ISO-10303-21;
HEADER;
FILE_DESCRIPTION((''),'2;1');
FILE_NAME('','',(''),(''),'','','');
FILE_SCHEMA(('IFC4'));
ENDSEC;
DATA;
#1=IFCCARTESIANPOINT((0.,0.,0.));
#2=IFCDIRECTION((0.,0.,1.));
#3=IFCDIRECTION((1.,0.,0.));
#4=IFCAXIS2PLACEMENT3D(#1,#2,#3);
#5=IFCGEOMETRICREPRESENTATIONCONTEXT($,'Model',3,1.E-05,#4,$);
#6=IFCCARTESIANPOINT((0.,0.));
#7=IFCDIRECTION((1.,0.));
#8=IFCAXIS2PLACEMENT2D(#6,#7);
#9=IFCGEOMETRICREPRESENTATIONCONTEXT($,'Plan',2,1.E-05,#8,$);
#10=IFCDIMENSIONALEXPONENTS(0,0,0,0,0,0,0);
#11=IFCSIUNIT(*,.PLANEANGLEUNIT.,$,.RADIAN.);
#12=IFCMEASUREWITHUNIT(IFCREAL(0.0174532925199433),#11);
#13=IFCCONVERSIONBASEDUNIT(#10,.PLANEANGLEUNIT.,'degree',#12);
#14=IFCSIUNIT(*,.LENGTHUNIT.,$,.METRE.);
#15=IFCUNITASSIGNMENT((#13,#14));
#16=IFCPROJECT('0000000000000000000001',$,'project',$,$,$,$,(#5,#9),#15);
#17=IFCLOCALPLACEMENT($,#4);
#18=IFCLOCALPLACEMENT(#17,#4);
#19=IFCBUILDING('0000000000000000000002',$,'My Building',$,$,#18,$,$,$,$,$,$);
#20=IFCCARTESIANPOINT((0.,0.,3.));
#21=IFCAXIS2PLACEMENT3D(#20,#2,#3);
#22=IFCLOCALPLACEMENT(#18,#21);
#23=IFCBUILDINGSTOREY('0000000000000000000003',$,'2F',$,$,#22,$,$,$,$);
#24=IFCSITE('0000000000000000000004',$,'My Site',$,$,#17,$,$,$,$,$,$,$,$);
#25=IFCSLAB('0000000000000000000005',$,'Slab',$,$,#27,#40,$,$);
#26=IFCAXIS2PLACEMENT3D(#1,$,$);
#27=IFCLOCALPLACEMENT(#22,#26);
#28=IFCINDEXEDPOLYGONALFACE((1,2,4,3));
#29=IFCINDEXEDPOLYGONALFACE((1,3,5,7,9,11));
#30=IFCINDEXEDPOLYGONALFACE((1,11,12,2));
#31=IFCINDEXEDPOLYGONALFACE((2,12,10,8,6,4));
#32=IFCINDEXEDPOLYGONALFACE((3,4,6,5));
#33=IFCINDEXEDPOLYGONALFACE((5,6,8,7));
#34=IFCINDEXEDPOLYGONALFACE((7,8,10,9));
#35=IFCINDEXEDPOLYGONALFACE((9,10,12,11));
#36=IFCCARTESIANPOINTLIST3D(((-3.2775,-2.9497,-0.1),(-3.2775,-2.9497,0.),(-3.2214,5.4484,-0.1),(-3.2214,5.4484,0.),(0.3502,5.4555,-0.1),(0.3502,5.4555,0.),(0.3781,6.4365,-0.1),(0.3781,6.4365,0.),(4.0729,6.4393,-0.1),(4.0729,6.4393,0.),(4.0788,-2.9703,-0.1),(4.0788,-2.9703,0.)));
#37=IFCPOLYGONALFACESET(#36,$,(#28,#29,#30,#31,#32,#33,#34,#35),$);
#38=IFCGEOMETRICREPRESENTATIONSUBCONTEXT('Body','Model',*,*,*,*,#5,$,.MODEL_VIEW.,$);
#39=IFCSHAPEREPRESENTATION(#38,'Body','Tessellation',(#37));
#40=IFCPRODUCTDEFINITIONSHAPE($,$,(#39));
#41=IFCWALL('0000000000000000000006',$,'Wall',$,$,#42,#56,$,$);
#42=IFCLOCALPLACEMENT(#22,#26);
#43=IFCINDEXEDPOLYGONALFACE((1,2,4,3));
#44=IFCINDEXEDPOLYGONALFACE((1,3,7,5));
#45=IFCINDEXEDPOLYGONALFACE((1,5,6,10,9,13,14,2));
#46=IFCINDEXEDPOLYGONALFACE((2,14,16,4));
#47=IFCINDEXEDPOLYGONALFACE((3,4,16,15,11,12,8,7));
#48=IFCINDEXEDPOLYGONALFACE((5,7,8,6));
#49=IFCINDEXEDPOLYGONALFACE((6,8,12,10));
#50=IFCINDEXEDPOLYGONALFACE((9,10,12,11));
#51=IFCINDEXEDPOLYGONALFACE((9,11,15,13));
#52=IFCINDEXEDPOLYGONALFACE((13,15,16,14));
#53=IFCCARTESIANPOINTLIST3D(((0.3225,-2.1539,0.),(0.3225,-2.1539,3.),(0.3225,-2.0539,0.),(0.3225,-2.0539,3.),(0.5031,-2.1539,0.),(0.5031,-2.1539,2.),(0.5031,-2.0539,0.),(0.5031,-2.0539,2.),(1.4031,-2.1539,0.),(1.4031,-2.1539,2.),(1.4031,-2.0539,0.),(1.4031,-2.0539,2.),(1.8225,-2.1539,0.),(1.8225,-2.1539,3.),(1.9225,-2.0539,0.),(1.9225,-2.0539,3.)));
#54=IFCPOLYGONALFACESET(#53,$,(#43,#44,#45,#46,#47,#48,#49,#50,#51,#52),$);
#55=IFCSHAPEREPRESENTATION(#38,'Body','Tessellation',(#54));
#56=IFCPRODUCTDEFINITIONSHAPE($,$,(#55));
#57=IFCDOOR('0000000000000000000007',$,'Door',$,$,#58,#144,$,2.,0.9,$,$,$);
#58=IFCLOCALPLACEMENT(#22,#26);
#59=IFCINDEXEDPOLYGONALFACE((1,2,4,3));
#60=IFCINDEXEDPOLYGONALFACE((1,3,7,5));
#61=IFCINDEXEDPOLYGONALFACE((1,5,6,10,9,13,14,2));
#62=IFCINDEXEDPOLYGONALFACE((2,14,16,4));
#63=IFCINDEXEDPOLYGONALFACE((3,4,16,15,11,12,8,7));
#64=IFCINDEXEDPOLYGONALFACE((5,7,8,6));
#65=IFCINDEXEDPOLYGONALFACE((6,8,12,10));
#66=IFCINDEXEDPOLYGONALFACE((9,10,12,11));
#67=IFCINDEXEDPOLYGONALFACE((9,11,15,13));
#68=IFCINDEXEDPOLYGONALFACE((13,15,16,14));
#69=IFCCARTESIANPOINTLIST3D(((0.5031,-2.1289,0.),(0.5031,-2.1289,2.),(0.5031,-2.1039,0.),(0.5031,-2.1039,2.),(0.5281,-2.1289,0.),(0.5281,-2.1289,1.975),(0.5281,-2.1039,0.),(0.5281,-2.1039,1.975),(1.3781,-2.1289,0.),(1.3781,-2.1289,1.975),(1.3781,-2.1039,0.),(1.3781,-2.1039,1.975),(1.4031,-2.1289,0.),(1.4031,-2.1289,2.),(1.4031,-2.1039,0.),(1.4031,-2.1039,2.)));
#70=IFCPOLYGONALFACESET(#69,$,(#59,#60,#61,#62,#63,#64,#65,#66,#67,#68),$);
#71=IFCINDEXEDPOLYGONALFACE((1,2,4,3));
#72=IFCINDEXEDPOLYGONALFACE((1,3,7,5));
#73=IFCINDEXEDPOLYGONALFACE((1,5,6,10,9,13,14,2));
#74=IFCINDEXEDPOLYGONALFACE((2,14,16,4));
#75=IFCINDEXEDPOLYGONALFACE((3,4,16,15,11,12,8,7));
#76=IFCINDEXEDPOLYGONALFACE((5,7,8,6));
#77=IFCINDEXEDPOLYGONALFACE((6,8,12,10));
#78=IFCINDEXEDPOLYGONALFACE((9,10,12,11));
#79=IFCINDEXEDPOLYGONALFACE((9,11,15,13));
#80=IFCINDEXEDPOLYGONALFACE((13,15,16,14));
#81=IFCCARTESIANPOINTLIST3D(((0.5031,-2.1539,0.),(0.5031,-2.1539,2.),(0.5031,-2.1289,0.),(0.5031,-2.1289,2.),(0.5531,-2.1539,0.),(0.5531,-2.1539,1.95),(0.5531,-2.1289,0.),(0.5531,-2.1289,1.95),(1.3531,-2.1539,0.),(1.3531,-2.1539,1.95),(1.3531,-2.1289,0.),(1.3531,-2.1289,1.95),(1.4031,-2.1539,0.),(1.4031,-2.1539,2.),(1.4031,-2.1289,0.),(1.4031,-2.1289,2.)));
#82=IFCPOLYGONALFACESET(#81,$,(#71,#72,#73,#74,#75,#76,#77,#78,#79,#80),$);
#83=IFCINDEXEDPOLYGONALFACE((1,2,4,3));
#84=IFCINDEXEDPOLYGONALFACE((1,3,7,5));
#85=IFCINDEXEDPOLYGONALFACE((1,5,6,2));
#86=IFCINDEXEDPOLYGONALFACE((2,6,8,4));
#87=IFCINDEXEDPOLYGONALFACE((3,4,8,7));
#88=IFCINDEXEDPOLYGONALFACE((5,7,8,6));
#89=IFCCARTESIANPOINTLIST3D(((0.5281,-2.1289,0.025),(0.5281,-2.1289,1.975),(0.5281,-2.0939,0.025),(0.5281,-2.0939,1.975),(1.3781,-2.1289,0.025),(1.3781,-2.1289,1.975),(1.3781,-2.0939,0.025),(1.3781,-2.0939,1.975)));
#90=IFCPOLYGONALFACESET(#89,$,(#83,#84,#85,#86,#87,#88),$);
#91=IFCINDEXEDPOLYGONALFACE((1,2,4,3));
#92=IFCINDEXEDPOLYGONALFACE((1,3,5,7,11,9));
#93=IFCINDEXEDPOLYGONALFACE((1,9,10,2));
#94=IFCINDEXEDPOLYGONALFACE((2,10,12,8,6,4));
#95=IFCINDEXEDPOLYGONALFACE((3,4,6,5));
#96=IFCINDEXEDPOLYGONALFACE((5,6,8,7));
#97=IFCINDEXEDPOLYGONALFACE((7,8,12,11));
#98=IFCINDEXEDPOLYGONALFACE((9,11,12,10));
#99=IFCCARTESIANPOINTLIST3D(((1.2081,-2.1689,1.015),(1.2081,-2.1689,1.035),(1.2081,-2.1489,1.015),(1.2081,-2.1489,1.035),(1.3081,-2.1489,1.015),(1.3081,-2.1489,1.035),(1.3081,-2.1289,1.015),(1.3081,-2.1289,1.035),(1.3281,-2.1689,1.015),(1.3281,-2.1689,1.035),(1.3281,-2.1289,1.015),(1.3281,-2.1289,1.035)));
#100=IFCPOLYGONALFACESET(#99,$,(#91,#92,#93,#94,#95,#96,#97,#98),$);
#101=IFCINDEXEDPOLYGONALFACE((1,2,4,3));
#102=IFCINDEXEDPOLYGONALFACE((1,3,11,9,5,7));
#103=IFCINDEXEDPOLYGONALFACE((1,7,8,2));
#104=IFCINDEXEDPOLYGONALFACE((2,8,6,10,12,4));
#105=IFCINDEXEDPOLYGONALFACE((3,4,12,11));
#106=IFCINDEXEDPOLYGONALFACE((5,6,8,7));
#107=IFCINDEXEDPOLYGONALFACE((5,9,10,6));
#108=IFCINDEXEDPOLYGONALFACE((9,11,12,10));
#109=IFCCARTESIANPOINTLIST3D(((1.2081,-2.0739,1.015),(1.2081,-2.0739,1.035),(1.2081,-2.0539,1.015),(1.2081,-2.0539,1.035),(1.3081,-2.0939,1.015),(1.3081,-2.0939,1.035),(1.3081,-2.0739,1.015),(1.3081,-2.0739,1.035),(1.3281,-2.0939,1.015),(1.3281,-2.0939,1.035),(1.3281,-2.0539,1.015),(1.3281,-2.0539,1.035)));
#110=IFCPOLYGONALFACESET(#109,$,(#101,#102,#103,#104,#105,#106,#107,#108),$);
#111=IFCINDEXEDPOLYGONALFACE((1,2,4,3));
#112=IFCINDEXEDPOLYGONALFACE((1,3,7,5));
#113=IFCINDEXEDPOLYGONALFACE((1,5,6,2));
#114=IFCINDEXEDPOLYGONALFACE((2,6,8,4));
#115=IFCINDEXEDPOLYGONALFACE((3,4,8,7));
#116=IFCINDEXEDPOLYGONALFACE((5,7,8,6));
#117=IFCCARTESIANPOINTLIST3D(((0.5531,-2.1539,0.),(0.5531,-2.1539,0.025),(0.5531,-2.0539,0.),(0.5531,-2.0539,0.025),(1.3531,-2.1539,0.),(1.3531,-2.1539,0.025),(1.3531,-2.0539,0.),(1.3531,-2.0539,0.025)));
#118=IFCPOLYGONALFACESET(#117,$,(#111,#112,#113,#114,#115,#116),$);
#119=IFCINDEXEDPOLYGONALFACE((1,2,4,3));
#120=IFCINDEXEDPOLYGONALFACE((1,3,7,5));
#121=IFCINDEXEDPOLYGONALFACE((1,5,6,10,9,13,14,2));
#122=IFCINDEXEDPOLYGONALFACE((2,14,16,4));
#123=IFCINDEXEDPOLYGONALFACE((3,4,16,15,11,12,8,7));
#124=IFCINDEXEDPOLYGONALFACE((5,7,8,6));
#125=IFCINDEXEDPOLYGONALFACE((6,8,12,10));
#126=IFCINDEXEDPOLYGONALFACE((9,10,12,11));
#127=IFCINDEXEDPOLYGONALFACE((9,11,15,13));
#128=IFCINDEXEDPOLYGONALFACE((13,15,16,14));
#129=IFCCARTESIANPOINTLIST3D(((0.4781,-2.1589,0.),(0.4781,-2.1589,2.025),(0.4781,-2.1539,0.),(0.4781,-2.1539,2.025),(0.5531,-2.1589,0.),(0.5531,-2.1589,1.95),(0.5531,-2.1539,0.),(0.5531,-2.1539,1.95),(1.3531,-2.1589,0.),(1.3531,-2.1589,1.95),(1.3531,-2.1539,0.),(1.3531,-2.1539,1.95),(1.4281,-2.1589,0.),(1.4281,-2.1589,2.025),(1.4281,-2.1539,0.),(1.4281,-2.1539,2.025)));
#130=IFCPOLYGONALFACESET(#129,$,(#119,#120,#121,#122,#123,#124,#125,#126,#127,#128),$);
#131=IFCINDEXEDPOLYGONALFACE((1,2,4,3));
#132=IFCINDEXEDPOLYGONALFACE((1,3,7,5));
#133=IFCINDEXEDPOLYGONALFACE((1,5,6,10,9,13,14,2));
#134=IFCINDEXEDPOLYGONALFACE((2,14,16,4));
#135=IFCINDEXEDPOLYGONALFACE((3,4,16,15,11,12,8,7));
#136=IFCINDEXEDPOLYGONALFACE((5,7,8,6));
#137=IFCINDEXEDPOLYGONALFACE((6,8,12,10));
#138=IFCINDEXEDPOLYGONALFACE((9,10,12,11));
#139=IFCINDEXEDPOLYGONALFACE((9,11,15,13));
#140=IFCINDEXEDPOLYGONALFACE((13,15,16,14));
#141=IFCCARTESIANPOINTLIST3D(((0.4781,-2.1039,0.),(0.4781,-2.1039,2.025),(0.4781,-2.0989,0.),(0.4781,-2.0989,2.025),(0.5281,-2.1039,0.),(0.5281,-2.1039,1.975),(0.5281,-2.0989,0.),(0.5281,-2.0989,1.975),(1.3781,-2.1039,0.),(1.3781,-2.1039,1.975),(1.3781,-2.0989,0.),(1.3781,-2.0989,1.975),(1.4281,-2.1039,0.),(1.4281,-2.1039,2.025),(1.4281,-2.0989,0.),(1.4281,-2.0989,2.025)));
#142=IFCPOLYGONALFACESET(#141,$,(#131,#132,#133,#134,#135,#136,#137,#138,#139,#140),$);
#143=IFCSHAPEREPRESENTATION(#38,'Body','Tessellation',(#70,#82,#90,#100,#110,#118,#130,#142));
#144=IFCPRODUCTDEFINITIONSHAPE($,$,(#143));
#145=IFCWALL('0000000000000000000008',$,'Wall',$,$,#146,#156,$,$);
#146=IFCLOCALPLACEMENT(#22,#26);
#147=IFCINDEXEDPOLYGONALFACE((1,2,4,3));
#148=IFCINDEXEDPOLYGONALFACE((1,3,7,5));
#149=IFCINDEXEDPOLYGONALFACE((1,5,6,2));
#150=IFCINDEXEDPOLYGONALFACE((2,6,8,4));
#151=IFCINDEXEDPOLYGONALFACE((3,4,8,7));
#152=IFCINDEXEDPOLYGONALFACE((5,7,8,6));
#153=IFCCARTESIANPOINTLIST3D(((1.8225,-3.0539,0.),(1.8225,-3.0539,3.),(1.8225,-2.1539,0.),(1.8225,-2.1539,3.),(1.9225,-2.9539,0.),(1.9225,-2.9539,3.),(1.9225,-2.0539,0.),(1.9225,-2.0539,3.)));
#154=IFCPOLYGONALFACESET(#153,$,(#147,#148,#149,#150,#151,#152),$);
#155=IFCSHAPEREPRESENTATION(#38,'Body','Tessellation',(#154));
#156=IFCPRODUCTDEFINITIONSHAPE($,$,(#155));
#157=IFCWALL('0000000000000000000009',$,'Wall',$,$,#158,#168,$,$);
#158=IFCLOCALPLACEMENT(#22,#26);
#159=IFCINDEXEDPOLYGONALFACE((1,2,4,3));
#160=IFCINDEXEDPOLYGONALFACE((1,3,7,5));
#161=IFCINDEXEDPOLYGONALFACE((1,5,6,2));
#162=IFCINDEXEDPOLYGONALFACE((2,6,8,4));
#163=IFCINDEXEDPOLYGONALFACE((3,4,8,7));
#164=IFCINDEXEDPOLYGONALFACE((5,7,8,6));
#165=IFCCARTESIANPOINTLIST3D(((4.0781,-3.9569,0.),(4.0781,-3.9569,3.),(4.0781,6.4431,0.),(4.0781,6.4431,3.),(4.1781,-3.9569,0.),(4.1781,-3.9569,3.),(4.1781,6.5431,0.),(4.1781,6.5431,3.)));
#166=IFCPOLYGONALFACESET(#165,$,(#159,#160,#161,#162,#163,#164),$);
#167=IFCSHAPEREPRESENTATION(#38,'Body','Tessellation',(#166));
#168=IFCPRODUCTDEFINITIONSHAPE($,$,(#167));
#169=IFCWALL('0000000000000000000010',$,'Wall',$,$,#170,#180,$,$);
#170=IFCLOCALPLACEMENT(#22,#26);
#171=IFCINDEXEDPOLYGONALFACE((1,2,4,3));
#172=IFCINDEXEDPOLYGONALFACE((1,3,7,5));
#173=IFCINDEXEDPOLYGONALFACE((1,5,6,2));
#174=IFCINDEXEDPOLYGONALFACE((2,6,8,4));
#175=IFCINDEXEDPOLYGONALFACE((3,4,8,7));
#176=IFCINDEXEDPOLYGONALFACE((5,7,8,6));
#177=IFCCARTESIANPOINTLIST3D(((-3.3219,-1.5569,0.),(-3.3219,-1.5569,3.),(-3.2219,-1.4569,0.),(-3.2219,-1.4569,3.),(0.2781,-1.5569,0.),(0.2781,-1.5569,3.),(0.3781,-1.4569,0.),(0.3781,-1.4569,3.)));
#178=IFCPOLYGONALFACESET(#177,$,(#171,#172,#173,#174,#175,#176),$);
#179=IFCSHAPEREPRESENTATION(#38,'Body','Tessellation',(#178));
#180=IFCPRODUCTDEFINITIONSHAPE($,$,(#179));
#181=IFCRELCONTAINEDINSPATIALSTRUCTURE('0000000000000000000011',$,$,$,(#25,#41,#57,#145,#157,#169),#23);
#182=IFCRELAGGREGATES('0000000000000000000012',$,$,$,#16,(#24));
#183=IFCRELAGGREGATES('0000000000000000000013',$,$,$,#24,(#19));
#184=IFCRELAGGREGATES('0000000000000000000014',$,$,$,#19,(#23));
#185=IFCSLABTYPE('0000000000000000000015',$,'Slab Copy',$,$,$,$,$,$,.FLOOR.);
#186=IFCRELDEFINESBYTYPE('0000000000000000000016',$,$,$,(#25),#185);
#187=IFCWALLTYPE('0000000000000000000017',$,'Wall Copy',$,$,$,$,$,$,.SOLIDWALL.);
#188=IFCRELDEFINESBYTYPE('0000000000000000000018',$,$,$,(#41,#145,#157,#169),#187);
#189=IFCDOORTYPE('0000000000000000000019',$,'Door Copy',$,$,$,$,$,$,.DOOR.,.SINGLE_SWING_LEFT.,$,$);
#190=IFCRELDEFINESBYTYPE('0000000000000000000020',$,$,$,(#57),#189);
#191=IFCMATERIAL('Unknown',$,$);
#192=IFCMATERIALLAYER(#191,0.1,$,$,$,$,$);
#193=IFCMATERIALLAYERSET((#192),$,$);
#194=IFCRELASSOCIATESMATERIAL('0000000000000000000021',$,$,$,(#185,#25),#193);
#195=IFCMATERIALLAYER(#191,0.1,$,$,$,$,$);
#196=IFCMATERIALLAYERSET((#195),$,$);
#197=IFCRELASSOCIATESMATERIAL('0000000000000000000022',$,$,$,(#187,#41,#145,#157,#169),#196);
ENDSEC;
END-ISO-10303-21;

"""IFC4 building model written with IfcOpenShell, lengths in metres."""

from ifc_helpers import new_model, entity, si_unit, converted_unit, frame, origin_with_axes, origin_2d_with_axis, place, context, subcontext, project, spatial, line, indexed_curve, outline, extrude, shape, source, transform, mapped, material, layer, layer_set, layer_usage, type_object, type_shapes, element, fill, save


model = new_model("IFC4")

# Units and contexts
model_context = context("Model", 3, precision=1e-05, world=origin_with_axes())
plan_context = context("Plan", 2, precision=1e-05, world=origin_2d_with_axis())
body_context_1 = subcontext(model_context, "Body", "Model", "MODEL_VIEW")
body_context_2 = subcontext(plan_context, "Body", "Plan", "PLAN_VIEW")
ifc_project = project(units=[converted_unit("PLANEANGLEUNIT", "degree", entity("IfcReal", 0.0174532925199433), si_unit("PLANEANGLEUNIT", "RADIAN"), dimensions=[0, 0, 0, 0, 0, 0, 0]), si_unit("LENGTHUNIT", "METRE")], contexts=[model_context, plan_context])

# Site, building, storey
site_placement = place(None, origin_with_axes())
site = spatial("IfcSite", under=ifc_project, at=site_placement, Name="My Site")
building_placement = place(site_placement, origin_with_axes())
building = spatial("IfcBuilding", under=site, at=building_placement, Name="My Building")
storey_placement = place(building_placement, frame((0.0, 0.0, 3.0), z_axis=(0.0, 0.0, 1.0), x_axis=(1.0, 0.0, 0.0)))
storey = spatial("IfcBuildingStorey", under=building, at=storey_placement, Name="2F")

# Slab
ifc_material = material(Name="Unknown")
ifc_layer_1 = layer(ifc_material, 0.1)
ifc_layer_set_1 = layer_set([ifc_layer_1])
ifc_layer_usage_1 = layer_usage(ifc_layer_set_1, "AXIS3", "POSITIVE", -0.1)
slab_type = type_object("IfcSlabType", Name="Slab Copy", PredefinedType="FLOOR", material=ifc_layer_set_1)
slab_placement = place(storey_placement, frame((-3.2775, -2.9497, 0.0), z_axis=(0.0, 0.0, 1.0), x_axis=(1.0, 0.0, 0.0)))
element("IfcSlab", 1, at=slab_placement, inside=storey, type_object=slab_type, material=ifc_layer_usage_1, Name="Slab", context=body_context_1, shape_type="SweptSolid", body=[
    extrude(outline(indexed_curve([(0.0, 0.0), (7.3564, -0.0206), (7.3504, 9.389), (3.6556, 9.3862), (3.6278, 8.4052), (0.0561, 8.3981), (0.0, 0.0)])), frame((0.0, 0.0, -0.1), z_axis=(0.0, 0.0, 1.0), x_axis=(1.0, 0.0, 0.0)), (0.0, 0.0, 1.0), 0.1),
])

# Wall, opening, door
ifc_layer_2 = layer(ifc_material, 0.1)
ifc_layer_set_2 = layer_set([ifc_layer_2])
ifc_layer_usage_2 = layer_usage(ifc_layer_set_2, "AXIS2", "POSITIVE", 0.0)
wall_type = type_object("IfcWallType", Name="Wall Copy", PredefinedType="SOLIDWALL", material=ifc_layer_set_2)
wall_1_placement = place(storey_placement, frame((0.3225, -2.1539, 0.0), z_axis=(0.0, 0.0, 1.0), x_axis=(1.0, 0.0, 0.0)))
wall_1 = element("IfcWall", 2, at=wall_1_placement, inside=storey, type_object=wall_type, material=ifc_layer_usage_2, Name="Wall", context=body_context_1, shape_type="SweptSolid", body=[
    extrude(outline(indexed_curve([(0.0, 0.0), (0.0, 0.1), (1.6, 0.1), (1.5, 0.0)], segments=[line(1, 2, 3, 4, 1)])), origin_with_axes(), (0.0, 0.0, 1.0), 3.0),
])
shared_shape_1 = source(origin_with_axes(), body_context_1, "Body", "SweptSolid", [
    extrude(outline(indexed_curve([(0.0, 0.0), (0.9, 0.0), (0.9, 2.0), (0.0, 2.0)], segments=[line(1, 2, 3, 4, 1)])), frame((0.0, -0.6, 0.0), z_axis=(0.0, -1.0, 0.0), x_axis=(1.0, 0.0, 0.0)), (0.0, 0.0, -1.0), 1.2),
])
opening_placement = place(wall_1_placement, frame((0.1806, 0.0, 0.0), z_axis=(0.0, 0.0, 1.0), x_axis=(1.0, 0.0, 0.0)))
opening = element("IfcOpeningElement", 3, at=opening_placement, cuts=wall_1, PredefinedType="OPENING", context=body_context_1, shape_type="MappedRepresentation", body=[
    mapped(shared_shape_1, transform((0.0, 0.0, 0.0), x_axis=(1.0, 0.0, 0.0), y_axis=(0.0, 1.0, 0.0), z_axis=(0.0, 0.0, 1.0), scale=1.0)),
])
door_type = type_object("IfcDoorType", Name="Door Copy", OperationType="SINGLE_SWING_LEFT", PredefinedType="DOOR")
shared_shape_2 = source(origin_with_axes(), body_context_1, "Body", "SweptSolid", [
    extrude(outline(indexed_curve([(0.0, 0.0), (0.0, 2.0), (0.9, 2.0), (0.9, 0.0), (0.875, 0.0), (0.875, 1.975), (0.025, 1.975), (0.025, 0.0)], segments=[line(1, 2, 3, 4, 5, 6, 7, 8, 1)])), frame((0.0, 0.025, 0.0), z_axis=(0.0, -1.0, 0.0), x_axis=(1.0, 0.0, 0.0)), (0.0, 0.0, -1.0), 0.025),
    extrude(outline(indexed_curve([(0.0, 0.0), (0.0, 2.0), (0.9, 2.0), (0.9, 0.0), (0.85, 0.0), (0.85, 1.95), (0.05, 1.95), (0.05, 0.0)], segments=[line(1, 2, 3, 4, 5, 6, 7, 8, 1)])), frame((0.0, 0.0, 0.0), z_axis=(0.0, -1.0, 0.0), x_axis=(1.0, 0.0, 0.0)), (0.0, 0.0, -1.0), 0.025),
    extrude(outline(indexed_curve([(0.0, 0.0), (0.85, 0.0), (0.85, 0.035), (0.0, 0.035)], segments=[line(1, 2, 3, 4, 1)])), frame((0.025, 0.025, 0.025), z_axis=(0.0, 0.0, 1.0), x_axis=(1.0, 0.0, 0.0)), (0.0, 0.0, 1.0), 1.95),
    extrude(outline(indexed_curve([(0.0, 0.0), (0.0, -0.04), (-0.12, -0.04), (-0.12, -0.02), (-0.02, -0.02), (-0.02, 0.0)], segments=[line(1, 2, 3, 4, 5, 6, 1)])), frame((0.825, 0.025, 1.015), z_axis=(0.0, 0.0, 1.0), x_axis=(1.0, 0.0, 0.0)), (0.0, 0.0, 1.0), 0.02),
    extrude(outline(indexed_curve([(0.0, 0.0), (0.0, 0.04), (-0.12, 0.04), (-0.12, 0.02), (-0.02, 0.02), (-0.02, 0.0)], segments=[line(1, 2, 3, 4, 5, 6, 1)])), frame((0.825, 0.06, 1.015), z_axis=(0.0, 0.0, 1.0), x_axis=(1.0, 0.0, 0.0)), (0.0, 0.0, 1.0), 0.02),
    extrude(outline(indexed_curve([(0.0, 0.0), (0.8, 0.0), (0.8, 0.1), (0.0, 0.1)], segments=[line(1, 2, 3, 4, 1)])), frame((0.05, 0.0, 0.0), z_axis=(0.0, 0.0, 1.0), x_axis=(1.0, 0.0, 0.0)), (0.0, 0.0, 1.0), 0.025),
    extrude(outline(indexed_curve([(0.0, 0.0), (0.0, 2.025), (0.95, 2.025), (0.95, 0.0), (0.875, 0.0), (0.875, 1.95), (0.075, 1.95), (0.075, 0.0)], segments=[line(1, 2, 3, 4, 5, 6, 7, 8, 1)])), frame((-0.025, -0.005, 0.0), z_axis=(0.0, -1.0, 0.0), x_axis=(1.0, 0.0, 0.0)), (0.0, 0.0, -1.0), 0.005),
    extrude(outline(indexed_curve([(0.0, 0.0), (0.0, 2.025), (0.95, 2.025), (0.95, 0.0), (0.9, 0.0), (0.9, 1.975), (0.05, 1.975), (0.05, 0.0)], segments=[line(1, 2, 3, 4, 5, 6, 7, 8, 1)])), frame((-0.025, 0.05, 0.0), z_axis=(0.0, -1.0, 0.0), x_axis=(1.0, 0.0, 0.0)), (0.0, 0.0, -1.0), 0.005),
])
shared_shape_3 = source(origin_with_axes(), body_context_2, "Body", "Curve2D", [
    entity("IfcIndexedPolyCurve", entity("IfcCartesianPointList2D", [[0.0, 0.0], [0.0, 0.05], [0.025, 0.05], [0.025, 0.025], [0.05, 0.025], [0.05, 0.0]]), [entity("IfcLineIndex", [1, 2, 3, 4, 5, 6, 1])]),
    entity("IfcIndexedPolyCurve", entity("IfcCartesianPointList2D", [[0.9, 0.0], [0.9, 0.05], [0.875, 0.05], [0.875, 0.025], [0.85, 0.025], [0.85, 0.0]]), [entity("IfcLineIndex", [1, 2, 3, 4, 5, 6, 1])]),
    entity("IfcTrimmedCurve", entity("IfcEllipse", entity("IfcAxis2Placement2D", entity("IfcCartesianPoint", [0.06, 0.05]), entity("IfcDirection", [1.0, 0.0])), 0.815, 0.85), [entity("IfcCartesianPoint", [0.875, 0.05])], [entity("IfcCartesianPoint", [0.06, 0.9])], True, "CARTESIAN"),
    entity("IfcIndexedPolyCurve", entity("IfcCartesianPointList2D", [[0.025, 0.05], [0.06, 0.05], [0.06, 0.9], [0.025, 0.9]]), [entity("IfcLineIndex", [1, 2, 3, 4, 1])]),
])
type_shapes(door_type, [shared_shape_2, shared_shape_3])
door_placement = place(opening_placement, origin_with_axes())
door = element("IfcDoor", 4, at=door_placement, inside=storey, type_object=door_type, Name="Door", OverallHeight=2.0, OverallWidth=0.9, shapes=[
    shape(body_context_1, "Body", "MappedRepresentation", [mapped(shared_shape_2, transform((0.0, 0.0, 0.0), x_axis=(1.0, 0.0, 0.0), y_axis=(0.0, 1.0, 0.0), z_axis=(0.0, 0.0, 1.0), scale=1.0))]),
    shape(body_context_2, "Body", "MappedRepresentation", [mapped(shared_shape_3, transform((0.0, 0.0, 0.0), x_axis=(1.0, 0.0, 0.0), y_axis=(0.0, 1.0, 0.0), z_axis=(0.0, 0.0, 1.0), scale=1.0))]),
])
fill(opening, door)

# Walls
ifc_layer_usage_3 = layer_usage(ifc_layer_set_2, "AXIS2", "POSITIVE", 0.0)
wall_2_placement = place(storey_placement, frame((1.8225, -2.1539, 0.0), z_axis=(0.0, 0.0, 1.0), x_axis=(0.0, -1.0, 0.0)))
element("IfcWall", 5, at=wall_2_placement, inside=storey, type_object=wall_type, material=ifc_layer_usage_3, Name="Wall", context=body_context_1, shape_type="SweptSolid", body=[
    extrude(outline(indexed_curve([(0.0, 0.0), (-0.1, 0.1), (0.8, 0.1), (0.9, 0.0)], segments=[line(1, 2, 3, 4, 1)])), origin_with_axes(), (0.0, 0.0, 1.0), 3.0),
])
ifc_layer_usage_4 = layer_usage(ifc_layer_set_2, "AXIS2", "POSITIVE", 0.0)
wall_3_placement = place(storey_placement, frame((4.1781, -3.9569, 0.0), z_axis=(0.0, 0.0, 1.0), x_axis=(0.0, 1.0, 0.0)))
element("IfcWall", 6, at=wall_3_placement, inside=storey, type_object=wall_type, material=ifc_layer_usage_4, Name="Wall", context=body_context_1, shape_type="SweptSolid", body=[
    extrude(outline(indexed_curve([(0.0, 0.0), (0.0, 0.1), (10.4, 0.1), (10.5, 0.0)], segments=[line(1, 2, 3, 4, 1)])), origin_with_axes(), (0.0, 0.0, 1.0), 3.0),
])
ifc_layer_usage_5 = layer_usage(ifc_layer_set_2, "AXIS2", "POSITIVE", 0.0)
wall_4_placement = place(storey_placement, frame((-3.3219, -1.5569, 0.0), z_axis=(0.0, 0.0, 1.0), x_axis=(1.0, 0.0, 0.0)))
element("IfcWall", 7, at=wall_4_placement, inside=storey, type_object=wall_type, material=ifc_layer_usage_5, Name="Wall", context=body_context_1, shape_type="SweptSolid", body=[
    extrude(outline(indexed_curve([(0.0, 0.0), (0.1, 0.1), (3.7, 0.1), (3.6, 0.0)], segments=[line(1, 2, 3, 4, 1)])), origin_with_axes(), (0.0, 0.0, 1.0), 3.0),
])

save(model, "model.ifc")
